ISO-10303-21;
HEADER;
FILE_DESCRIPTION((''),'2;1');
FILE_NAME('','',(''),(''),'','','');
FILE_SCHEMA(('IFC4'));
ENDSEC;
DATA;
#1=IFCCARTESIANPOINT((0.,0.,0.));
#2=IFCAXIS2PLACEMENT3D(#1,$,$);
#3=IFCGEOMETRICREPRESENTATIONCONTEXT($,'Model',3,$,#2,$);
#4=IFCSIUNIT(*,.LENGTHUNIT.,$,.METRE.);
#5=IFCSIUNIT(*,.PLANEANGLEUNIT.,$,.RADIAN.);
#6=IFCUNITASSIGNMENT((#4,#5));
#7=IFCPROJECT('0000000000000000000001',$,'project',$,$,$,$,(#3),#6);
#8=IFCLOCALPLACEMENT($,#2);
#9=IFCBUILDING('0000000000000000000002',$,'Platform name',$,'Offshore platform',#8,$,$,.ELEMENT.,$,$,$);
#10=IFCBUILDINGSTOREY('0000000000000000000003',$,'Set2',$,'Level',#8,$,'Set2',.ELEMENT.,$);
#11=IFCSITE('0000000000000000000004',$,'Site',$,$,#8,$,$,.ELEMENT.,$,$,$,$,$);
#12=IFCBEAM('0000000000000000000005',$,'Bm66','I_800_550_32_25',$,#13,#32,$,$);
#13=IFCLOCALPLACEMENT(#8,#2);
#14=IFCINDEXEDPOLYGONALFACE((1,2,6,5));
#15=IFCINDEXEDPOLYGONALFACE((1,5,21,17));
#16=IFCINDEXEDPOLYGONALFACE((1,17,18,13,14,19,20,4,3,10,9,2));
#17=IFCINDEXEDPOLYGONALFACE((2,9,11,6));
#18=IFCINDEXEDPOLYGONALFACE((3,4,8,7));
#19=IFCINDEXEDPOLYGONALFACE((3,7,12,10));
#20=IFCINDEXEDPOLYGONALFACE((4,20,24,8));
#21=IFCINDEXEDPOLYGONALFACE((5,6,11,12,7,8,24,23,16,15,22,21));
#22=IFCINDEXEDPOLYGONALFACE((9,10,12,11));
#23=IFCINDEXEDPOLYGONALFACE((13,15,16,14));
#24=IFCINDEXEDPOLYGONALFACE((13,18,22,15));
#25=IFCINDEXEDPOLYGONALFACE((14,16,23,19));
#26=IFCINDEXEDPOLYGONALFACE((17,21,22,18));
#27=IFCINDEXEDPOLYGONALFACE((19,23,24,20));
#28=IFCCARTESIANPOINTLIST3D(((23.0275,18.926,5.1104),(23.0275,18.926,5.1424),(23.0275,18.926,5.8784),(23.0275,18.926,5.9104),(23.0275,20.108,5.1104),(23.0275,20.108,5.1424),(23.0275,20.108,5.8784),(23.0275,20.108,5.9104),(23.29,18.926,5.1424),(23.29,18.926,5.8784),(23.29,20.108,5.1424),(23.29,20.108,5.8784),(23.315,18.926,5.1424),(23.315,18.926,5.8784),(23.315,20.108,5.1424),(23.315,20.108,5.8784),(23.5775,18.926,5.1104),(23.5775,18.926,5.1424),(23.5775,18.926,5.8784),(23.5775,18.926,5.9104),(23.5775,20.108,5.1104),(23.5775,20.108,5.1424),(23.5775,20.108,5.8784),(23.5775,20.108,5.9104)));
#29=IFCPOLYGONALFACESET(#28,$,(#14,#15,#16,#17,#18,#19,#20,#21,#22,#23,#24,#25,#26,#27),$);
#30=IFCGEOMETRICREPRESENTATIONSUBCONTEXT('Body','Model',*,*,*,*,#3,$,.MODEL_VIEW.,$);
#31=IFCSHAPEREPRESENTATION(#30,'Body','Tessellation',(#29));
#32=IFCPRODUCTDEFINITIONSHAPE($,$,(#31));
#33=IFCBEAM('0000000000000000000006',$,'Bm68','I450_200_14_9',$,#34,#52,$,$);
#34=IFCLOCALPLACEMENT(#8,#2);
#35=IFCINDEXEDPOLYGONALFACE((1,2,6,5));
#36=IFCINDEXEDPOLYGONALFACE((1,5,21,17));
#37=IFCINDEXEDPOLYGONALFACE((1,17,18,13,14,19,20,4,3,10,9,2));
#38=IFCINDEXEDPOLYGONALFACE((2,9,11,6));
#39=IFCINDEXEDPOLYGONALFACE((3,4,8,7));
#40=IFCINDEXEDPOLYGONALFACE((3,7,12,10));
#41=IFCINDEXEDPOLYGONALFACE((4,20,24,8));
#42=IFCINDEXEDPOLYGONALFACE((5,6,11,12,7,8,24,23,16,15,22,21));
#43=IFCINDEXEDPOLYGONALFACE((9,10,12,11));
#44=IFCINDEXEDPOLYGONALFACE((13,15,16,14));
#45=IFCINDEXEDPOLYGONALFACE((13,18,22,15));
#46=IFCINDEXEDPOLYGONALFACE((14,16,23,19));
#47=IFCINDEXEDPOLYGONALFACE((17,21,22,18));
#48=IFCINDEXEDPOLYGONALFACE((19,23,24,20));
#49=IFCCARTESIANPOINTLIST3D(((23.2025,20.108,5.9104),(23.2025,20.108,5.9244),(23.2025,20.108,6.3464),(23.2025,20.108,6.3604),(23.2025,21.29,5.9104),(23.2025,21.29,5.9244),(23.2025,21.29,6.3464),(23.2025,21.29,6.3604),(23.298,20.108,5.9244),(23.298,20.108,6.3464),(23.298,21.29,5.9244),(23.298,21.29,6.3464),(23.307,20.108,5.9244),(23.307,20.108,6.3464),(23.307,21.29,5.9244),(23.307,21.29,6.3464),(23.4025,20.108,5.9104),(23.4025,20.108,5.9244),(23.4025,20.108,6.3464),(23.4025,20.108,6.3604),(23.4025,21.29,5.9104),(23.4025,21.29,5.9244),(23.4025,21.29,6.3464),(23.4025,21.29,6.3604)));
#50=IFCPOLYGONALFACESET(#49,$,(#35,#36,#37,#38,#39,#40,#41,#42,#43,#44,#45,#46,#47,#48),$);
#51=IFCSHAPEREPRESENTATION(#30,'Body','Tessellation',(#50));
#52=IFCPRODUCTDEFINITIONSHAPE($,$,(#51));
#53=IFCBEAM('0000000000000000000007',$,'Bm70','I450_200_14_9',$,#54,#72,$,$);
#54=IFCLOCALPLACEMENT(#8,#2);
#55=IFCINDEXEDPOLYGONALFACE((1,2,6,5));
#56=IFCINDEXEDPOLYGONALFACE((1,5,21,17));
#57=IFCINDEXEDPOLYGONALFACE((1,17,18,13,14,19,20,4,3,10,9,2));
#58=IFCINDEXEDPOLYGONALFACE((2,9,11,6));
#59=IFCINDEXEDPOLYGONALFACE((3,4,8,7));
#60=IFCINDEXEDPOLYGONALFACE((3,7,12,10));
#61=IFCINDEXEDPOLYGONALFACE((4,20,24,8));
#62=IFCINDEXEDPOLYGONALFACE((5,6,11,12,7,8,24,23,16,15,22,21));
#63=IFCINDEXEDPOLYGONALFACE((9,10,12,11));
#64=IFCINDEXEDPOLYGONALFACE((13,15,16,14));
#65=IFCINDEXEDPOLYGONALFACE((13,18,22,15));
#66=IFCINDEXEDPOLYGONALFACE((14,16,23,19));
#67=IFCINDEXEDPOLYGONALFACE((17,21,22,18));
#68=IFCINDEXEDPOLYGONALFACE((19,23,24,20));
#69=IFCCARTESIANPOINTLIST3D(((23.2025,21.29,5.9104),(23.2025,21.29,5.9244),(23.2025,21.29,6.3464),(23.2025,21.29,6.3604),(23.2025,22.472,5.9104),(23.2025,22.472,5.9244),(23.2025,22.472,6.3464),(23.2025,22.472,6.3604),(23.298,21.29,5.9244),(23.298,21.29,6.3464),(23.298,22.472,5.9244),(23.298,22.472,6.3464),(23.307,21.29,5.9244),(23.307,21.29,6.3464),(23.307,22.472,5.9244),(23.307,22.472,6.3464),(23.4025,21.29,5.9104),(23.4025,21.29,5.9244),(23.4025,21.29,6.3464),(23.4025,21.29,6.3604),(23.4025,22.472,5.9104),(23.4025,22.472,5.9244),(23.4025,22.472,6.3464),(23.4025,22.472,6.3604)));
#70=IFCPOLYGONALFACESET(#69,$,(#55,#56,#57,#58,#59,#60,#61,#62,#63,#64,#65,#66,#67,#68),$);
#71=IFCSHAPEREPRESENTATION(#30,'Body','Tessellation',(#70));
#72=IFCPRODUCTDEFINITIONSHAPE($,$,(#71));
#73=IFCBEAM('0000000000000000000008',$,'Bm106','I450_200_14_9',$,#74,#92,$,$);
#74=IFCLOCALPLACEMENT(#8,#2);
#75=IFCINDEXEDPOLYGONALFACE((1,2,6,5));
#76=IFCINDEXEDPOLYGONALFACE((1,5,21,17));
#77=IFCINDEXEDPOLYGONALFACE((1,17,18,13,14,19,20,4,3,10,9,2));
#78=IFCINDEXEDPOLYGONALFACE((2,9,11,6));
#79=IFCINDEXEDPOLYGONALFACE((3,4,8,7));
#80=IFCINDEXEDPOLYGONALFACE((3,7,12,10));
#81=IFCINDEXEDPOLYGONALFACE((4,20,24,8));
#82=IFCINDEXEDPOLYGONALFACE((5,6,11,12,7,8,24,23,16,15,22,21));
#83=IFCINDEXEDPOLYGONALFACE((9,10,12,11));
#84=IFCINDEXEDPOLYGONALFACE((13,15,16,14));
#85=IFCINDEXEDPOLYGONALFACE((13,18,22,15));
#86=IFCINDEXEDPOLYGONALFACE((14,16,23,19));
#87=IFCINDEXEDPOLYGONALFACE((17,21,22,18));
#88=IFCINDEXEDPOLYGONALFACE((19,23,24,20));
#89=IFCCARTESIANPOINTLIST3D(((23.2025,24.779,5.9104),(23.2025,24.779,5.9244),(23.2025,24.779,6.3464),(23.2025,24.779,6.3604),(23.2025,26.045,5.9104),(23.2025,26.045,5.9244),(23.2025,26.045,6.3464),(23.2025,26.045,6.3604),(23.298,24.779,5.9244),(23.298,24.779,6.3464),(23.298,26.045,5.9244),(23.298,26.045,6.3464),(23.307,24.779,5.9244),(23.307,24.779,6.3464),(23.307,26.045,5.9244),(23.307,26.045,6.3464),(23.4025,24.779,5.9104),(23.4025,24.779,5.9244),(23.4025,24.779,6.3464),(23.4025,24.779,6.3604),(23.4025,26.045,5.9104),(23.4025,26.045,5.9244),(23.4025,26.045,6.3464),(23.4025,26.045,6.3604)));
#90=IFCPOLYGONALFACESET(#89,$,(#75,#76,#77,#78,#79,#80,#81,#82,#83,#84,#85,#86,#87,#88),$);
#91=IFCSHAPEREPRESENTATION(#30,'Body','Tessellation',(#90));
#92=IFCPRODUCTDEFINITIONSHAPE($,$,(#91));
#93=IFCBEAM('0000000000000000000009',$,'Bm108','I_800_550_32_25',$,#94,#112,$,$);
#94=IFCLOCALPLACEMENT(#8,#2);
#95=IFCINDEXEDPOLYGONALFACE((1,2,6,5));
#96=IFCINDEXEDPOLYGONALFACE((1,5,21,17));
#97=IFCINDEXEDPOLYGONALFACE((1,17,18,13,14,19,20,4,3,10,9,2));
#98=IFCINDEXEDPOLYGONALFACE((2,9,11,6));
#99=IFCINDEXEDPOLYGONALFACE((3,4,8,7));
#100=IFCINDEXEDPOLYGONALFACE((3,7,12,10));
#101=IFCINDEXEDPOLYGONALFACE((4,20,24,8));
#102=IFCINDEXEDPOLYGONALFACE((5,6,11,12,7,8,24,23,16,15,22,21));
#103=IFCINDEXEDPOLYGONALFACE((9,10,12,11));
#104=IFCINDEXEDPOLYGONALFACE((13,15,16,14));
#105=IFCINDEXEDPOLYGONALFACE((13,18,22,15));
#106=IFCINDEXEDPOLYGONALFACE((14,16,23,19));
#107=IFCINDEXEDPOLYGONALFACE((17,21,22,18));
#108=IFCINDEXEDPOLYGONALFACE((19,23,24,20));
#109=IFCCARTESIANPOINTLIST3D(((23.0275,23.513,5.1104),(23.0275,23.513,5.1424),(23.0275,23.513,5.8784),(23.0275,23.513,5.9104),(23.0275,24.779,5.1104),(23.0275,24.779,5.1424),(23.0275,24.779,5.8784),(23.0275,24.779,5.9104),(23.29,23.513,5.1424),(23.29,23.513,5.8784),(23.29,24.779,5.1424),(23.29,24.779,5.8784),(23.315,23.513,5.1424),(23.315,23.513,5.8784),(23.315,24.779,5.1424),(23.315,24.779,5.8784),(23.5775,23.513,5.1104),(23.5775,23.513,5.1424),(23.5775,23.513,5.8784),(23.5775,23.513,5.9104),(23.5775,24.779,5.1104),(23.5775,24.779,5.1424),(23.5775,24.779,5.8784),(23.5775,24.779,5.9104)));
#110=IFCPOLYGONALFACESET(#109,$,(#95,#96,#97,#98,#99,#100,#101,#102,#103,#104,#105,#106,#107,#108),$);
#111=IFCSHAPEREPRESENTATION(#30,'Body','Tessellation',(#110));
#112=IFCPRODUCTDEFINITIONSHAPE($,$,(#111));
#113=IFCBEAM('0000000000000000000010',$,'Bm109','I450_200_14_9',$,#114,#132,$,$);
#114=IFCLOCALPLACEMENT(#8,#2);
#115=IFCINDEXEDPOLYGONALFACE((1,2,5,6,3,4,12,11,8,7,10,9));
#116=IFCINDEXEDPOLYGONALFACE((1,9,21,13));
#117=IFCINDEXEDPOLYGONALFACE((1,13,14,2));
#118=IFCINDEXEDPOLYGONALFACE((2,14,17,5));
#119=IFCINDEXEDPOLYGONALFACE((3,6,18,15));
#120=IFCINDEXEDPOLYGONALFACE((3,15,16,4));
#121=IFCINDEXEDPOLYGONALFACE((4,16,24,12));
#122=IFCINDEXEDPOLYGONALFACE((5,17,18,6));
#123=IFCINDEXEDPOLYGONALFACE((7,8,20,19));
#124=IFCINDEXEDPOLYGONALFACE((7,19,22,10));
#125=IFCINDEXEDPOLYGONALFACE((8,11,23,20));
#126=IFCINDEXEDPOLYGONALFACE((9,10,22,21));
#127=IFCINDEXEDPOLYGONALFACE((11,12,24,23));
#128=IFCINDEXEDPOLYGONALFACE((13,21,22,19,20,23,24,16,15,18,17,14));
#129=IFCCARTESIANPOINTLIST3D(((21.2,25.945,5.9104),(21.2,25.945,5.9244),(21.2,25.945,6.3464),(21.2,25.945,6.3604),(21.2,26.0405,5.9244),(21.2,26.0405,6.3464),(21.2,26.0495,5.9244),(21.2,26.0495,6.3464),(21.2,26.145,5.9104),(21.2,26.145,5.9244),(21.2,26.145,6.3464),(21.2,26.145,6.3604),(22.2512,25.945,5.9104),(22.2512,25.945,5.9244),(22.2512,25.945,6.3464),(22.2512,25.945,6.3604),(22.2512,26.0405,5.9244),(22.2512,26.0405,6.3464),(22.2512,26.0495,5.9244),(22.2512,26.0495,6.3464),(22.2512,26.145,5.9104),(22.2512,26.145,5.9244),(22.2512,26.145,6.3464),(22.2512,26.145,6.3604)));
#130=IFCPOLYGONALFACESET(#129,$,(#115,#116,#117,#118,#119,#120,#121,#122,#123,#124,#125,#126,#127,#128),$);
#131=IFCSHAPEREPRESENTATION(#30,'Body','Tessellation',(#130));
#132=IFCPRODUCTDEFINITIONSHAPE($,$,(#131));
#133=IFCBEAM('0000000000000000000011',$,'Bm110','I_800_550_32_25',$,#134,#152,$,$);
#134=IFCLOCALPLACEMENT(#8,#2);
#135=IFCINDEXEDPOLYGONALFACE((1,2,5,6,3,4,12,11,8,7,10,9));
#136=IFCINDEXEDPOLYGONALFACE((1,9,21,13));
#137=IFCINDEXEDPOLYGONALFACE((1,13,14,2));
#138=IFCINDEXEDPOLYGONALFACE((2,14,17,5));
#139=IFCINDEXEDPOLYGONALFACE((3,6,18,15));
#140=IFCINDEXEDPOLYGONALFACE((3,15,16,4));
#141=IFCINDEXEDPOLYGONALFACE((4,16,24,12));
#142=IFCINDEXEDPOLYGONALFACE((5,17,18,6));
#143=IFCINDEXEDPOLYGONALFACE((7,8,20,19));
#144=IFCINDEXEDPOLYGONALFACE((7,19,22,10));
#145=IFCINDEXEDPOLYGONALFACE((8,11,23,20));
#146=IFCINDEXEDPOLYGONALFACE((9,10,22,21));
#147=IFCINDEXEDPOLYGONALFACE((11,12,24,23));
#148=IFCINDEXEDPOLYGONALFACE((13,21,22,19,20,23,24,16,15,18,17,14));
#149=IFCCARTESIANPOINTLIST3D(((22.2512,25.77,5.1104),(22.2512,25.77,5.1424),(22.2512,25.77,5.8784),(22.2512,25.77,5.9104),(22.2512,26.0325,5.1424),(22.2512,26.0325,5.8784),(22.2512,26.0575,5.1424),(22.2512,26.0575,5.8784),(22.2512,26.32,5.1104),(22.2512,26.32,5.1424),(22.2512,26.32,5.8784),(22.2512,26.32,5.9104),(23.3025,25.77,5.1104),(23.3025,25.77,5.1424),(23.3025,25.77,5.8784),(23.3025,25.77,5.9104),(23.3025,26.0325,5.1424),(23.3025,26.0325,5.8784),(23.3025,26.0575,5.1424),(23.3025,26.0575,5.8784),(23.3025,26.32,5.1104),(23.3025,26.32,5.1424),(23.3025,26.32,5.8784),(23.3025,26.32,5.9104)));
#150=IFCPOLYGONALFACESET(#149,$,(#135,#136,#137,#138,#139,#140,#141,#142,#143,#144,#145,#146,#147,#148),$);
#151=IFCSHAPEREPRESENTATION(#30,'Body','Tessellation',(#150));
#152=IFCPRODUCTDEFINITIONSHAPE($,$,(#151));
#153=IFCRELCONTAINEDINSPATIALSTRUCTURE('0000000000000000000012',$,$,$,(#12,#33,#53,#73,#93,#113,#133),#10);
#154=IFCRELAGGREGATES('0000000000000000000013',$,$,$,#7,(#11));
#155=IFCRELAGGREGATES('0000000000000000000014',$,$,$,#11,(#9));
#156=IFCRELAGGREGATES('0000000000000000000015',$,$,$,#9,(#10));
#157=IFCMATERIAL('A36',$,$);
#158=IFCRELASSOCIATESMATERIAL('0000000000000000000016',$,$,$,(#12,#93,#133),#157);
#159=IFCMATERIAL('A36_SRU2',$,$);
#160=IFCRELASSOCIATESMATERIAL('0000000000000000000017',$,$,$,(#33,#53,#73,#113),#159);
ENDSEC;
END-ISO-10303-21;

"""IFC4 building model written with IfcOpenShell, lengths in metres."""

from ifc_helpers import new_model, si_unit, frame, origin, origin_2d, place, context, subcontext, project, spatial, i_section, extrude, source, transform, mapped, material, element, save


model = new_model("IFC4")

# Units and contexts
model_context = context("Model", 3, world=origin())
body_context = subcontext(model_context, "Body", "Model", "MODEL_VIEW")
ifc_project = project(units=[si_unit("LENGTHUNIT", "METRE"), si_unit("PLANEANGLEUNIT", "RADIAN")], contexts=[model_context])

# Site, building, storey
placement_1 = place(None, origin())
site = spatial("IfcSite", under=ifc_project, at=placement_1, Name="Site", CompositionType="ELEMENT")
building = spatial("IfcBuilding", under=site, at=placement_1, Name="Platform name", ObjectType="Offshore platform", CompositionType="ELEMENT")
storey = spatial("IfcBuildingStorey", under=building, at=placement_1, Name="Set2", ObjectType="Level", LongName="Set2", CompositionType="ELEMENT")

# Beams
ifc_material_1 = material(Name="A36_SRU2")
ifc_material_2 = material(Name="A36")
shared_shape_1 = source(origin(), body_context, "Body", "SweptSolid", [
    extrude(i_section(OverallWidth=0.55, OverallDepth=0.8, WebThickness=0.025, FlangeThickness=0.032, FilletRadius=0.0, at=origin_2d()), frame((0.0, 0.0, 0.0), z_axis=(0.0, -1.0, 0.0), x_axis=(1.0, 0.0, 0.0)), (0.0, 0.0, 1.0), 1.182),
])
placement_2 = place(None, origin())
placement_3 = place(placement_2, origin())
placement_4 = place(placement_3, origin())
beam_1_placement = place(placement_4, frame((23.3025, 20.108, 5.5104)))
element("IfcBeam", 1, at=beam_1_placement, inside=storey, material=ifc_material_2, Name="Bm66", Description="I_800_550_32_25", context=body_context, shape_type="MappedRepresentation", body=[
    mapped(shared_shape_1, transform((0.0, 0.0, 0.0), scale=1.0)),
])
shared_shape_2 = source(origin(), body_context, "Body", "SweptSolid", [
    extrude(i_section(OverallWidth=0.2, OverallDepth=0.45, WebThickness=0.009, FlangeThickness=0.014, FilletRadius=0.0, at=origin_2d()), frame((0.0, 0.0, 0.0), z_axis=(0.0, 1.0, 0.0), x_axis=(-1.0, 0.0, 0.0)), (0.0, 0.0, 1.0), 1.182),
])
placement_5 = place(None, origin())
placement_6 = place(placement_5, origin())
placement_7 = place(placement_6, origin())
beam_2_placement = place(placement_7, frame((23.3025, 20.108, 6.1354)))
element("IfcBeam", 2, at=beam_2_placement, inside=storey, material=ifc_material_1, Name="Bm68", Description="I450_200_14_9", context=body_context, shape_type="MappedRepresentation", body=[
    mapped(shared_shape_2, transform((0.0, 0.0, 0.0), scale=1.0)),
])
shared_shape_3 = source(origin(), body_context, "Body", "SweptSolid", [
    extrude(i_section(OverallWidth=0.2, OverallDepth=0.45, WebThickness=0.009, FlangeThickness=0.014, FilletRadius=0.0, at=origin_2d()), frame((0.0, 0.0, 0.0), z_axis=(0.0, 1.0, 0.0), x_axis=(-1.0, 0.0, 0.0)), (0.0, 0.0, 1.0), 1.182),
])
placement_8 = place(None, origin())
placement_9 = place(placement_8, origin())
placement_10 = place(placement_9, origin())
beam_3_placement = place(placement_10, frame((23.3025, 21.29, 6.1354)))
element("IfcBeam", 3, at=beam_3_placement, inside=storey, material=ifc_material_1, Name="Bm70", Description="I450_200_14_9", context=body_context, shape_type="MappedRepresentation", body=[
    mapped(shared_shape_3, transform((0.0, 0.0, 0.0), scale=1.0)),
])
shared_shape_4 = source(origin(), body_context, "Body", "SweptSolid", [
    extrude(i_section(OverallWidth=0.2, OverallDepth=0.45, WebThickness=0.009, FlangeThickness=0.014, FilletRadius=0.0, at=origin_2d()), frame((0.0, 0.0, 0.0), z_axis=(0.0, 1.0, 0.0), x_axis=(-1.0, 0.0, 0.0)), (0.0, 0.0, 1.0), 1.266),
])
placement_11 = place(None, origin())
placement_12 = place(placement_11, origin())
placement_13 = place(placement_12, origin())
beam_4_placement = place(placement_13, frame((23.3025, 24.779, 6.1354)))
element("IfcBeam", 4, at=beam_4_placement, inside=storey, material=ifc_material_1, Name="Bm106", Description="I450_200_14_9", context=body_context, shape_type="MappedRepresentation", body=[
    mapped(shared_shape_4, transform((0.0, 0.0, 0.0), scale=1.0)),
])
shared_shape_5 = source(origin(), body_context, "Body", "SweptSolid", [
    extrude(i_section(OverallWidth=0.55, OverallDepth=0.8, WebThickness=0.025, FlangeThickness=0.032, FilletRadius=0.0, at=origin_2d()), frame((0.0, 0.0, 0.0), z_axis=(0.0, -1.0, 0.0), x_axis=(1.0, 0.0, 0.0)), (0.0, 0.0, 1.0), 1.266),
])
placement_14 = place(None, origin())
placement_15 = place(placement_14, origin())
placement_16 = place(placement_15, origin())
beam_5_placement = place(placement_16, frame((23.3025, 24.779, 5.5104)))
element("IfcBeam", 5, at=beam_5_placement, inside=storey, material=ifc_material_2, Name="Bm108", Description="I_800_550_32_25", context=body_context, shape_type="MappedRepresentation", body=[
    mapped(shared_shape_5, transform((0.0, 0.0, 0.0), scale=1.0)),
])
shared_shape_6 = source(origin(), body_context, "Body", "SweptSolid", [
    extrude(i_section(OverallWidth=0.2, OverallDepth=0.45, WebThickness=0.009, FlangeThickness=0.014, FilletRadius=0.0, at=origin_2d()), frame((0.0, 0.0, 0.0), z_axis=(-1.0, 0.0, 0.0), x_axis=(0.0, -1.0, 0.0)), (0.0, 0.0, 1.0), 1.0513),
])
placement_17 = place(None, origin())
placement_18 = place(placement_17, origin())
placement_19 = place(placement_18, origin())
beam_6_placement = place(placement_19, frame((22.2512, 26.045, 6.1354)))
element("IfcBeam", 6, at=beam_6_placement, inside=storey, material=ifc_material_1, Name="Bm109", Description="I450_200_14_9", context=body_context, shape_type="MappedRepresentation", body=[
    mapped(shared_shape_6, transform((0.0, 0.0, 0.0), scale=1.0)),
])
shared_shape_7 = source(origin(), body_context, "Body", "SweptSolid", [
    extrude(i_section(OverallWidth=0.55, OverallDepth=0.8, WebThickness=0.025, FlangeThickness=0.032, FilletRadius=0.0, at=origin_2d()), frame((0.0, 0.0, 0.0), z_axis=(1.0, 0.0, 0.0), x_axis=(0.0, 1.0, 0.0)), (0.0, 0.0, 1.0), 1.0513),
])
placement_20 = place(None, origin())
placement_21 = place(placement_20, origin())
placement_22 = place(placement_21, origin())
beam_7_placement = place(placement_22, frame((22.2512, 26.045, 5.5104)))
element("IfcBeam", 7, at=beam_7_placement, inside=storey, material=ifc_material_2, Name="Bm110", Description="I_800_550_32_25", context=body_context, shape_type="MappedRepresentation", body=[
    mapped(shared_shape_7, transform((0.0, 0.0, 0.0), scale=1.0)),
])

save(model, "model.ifc")
